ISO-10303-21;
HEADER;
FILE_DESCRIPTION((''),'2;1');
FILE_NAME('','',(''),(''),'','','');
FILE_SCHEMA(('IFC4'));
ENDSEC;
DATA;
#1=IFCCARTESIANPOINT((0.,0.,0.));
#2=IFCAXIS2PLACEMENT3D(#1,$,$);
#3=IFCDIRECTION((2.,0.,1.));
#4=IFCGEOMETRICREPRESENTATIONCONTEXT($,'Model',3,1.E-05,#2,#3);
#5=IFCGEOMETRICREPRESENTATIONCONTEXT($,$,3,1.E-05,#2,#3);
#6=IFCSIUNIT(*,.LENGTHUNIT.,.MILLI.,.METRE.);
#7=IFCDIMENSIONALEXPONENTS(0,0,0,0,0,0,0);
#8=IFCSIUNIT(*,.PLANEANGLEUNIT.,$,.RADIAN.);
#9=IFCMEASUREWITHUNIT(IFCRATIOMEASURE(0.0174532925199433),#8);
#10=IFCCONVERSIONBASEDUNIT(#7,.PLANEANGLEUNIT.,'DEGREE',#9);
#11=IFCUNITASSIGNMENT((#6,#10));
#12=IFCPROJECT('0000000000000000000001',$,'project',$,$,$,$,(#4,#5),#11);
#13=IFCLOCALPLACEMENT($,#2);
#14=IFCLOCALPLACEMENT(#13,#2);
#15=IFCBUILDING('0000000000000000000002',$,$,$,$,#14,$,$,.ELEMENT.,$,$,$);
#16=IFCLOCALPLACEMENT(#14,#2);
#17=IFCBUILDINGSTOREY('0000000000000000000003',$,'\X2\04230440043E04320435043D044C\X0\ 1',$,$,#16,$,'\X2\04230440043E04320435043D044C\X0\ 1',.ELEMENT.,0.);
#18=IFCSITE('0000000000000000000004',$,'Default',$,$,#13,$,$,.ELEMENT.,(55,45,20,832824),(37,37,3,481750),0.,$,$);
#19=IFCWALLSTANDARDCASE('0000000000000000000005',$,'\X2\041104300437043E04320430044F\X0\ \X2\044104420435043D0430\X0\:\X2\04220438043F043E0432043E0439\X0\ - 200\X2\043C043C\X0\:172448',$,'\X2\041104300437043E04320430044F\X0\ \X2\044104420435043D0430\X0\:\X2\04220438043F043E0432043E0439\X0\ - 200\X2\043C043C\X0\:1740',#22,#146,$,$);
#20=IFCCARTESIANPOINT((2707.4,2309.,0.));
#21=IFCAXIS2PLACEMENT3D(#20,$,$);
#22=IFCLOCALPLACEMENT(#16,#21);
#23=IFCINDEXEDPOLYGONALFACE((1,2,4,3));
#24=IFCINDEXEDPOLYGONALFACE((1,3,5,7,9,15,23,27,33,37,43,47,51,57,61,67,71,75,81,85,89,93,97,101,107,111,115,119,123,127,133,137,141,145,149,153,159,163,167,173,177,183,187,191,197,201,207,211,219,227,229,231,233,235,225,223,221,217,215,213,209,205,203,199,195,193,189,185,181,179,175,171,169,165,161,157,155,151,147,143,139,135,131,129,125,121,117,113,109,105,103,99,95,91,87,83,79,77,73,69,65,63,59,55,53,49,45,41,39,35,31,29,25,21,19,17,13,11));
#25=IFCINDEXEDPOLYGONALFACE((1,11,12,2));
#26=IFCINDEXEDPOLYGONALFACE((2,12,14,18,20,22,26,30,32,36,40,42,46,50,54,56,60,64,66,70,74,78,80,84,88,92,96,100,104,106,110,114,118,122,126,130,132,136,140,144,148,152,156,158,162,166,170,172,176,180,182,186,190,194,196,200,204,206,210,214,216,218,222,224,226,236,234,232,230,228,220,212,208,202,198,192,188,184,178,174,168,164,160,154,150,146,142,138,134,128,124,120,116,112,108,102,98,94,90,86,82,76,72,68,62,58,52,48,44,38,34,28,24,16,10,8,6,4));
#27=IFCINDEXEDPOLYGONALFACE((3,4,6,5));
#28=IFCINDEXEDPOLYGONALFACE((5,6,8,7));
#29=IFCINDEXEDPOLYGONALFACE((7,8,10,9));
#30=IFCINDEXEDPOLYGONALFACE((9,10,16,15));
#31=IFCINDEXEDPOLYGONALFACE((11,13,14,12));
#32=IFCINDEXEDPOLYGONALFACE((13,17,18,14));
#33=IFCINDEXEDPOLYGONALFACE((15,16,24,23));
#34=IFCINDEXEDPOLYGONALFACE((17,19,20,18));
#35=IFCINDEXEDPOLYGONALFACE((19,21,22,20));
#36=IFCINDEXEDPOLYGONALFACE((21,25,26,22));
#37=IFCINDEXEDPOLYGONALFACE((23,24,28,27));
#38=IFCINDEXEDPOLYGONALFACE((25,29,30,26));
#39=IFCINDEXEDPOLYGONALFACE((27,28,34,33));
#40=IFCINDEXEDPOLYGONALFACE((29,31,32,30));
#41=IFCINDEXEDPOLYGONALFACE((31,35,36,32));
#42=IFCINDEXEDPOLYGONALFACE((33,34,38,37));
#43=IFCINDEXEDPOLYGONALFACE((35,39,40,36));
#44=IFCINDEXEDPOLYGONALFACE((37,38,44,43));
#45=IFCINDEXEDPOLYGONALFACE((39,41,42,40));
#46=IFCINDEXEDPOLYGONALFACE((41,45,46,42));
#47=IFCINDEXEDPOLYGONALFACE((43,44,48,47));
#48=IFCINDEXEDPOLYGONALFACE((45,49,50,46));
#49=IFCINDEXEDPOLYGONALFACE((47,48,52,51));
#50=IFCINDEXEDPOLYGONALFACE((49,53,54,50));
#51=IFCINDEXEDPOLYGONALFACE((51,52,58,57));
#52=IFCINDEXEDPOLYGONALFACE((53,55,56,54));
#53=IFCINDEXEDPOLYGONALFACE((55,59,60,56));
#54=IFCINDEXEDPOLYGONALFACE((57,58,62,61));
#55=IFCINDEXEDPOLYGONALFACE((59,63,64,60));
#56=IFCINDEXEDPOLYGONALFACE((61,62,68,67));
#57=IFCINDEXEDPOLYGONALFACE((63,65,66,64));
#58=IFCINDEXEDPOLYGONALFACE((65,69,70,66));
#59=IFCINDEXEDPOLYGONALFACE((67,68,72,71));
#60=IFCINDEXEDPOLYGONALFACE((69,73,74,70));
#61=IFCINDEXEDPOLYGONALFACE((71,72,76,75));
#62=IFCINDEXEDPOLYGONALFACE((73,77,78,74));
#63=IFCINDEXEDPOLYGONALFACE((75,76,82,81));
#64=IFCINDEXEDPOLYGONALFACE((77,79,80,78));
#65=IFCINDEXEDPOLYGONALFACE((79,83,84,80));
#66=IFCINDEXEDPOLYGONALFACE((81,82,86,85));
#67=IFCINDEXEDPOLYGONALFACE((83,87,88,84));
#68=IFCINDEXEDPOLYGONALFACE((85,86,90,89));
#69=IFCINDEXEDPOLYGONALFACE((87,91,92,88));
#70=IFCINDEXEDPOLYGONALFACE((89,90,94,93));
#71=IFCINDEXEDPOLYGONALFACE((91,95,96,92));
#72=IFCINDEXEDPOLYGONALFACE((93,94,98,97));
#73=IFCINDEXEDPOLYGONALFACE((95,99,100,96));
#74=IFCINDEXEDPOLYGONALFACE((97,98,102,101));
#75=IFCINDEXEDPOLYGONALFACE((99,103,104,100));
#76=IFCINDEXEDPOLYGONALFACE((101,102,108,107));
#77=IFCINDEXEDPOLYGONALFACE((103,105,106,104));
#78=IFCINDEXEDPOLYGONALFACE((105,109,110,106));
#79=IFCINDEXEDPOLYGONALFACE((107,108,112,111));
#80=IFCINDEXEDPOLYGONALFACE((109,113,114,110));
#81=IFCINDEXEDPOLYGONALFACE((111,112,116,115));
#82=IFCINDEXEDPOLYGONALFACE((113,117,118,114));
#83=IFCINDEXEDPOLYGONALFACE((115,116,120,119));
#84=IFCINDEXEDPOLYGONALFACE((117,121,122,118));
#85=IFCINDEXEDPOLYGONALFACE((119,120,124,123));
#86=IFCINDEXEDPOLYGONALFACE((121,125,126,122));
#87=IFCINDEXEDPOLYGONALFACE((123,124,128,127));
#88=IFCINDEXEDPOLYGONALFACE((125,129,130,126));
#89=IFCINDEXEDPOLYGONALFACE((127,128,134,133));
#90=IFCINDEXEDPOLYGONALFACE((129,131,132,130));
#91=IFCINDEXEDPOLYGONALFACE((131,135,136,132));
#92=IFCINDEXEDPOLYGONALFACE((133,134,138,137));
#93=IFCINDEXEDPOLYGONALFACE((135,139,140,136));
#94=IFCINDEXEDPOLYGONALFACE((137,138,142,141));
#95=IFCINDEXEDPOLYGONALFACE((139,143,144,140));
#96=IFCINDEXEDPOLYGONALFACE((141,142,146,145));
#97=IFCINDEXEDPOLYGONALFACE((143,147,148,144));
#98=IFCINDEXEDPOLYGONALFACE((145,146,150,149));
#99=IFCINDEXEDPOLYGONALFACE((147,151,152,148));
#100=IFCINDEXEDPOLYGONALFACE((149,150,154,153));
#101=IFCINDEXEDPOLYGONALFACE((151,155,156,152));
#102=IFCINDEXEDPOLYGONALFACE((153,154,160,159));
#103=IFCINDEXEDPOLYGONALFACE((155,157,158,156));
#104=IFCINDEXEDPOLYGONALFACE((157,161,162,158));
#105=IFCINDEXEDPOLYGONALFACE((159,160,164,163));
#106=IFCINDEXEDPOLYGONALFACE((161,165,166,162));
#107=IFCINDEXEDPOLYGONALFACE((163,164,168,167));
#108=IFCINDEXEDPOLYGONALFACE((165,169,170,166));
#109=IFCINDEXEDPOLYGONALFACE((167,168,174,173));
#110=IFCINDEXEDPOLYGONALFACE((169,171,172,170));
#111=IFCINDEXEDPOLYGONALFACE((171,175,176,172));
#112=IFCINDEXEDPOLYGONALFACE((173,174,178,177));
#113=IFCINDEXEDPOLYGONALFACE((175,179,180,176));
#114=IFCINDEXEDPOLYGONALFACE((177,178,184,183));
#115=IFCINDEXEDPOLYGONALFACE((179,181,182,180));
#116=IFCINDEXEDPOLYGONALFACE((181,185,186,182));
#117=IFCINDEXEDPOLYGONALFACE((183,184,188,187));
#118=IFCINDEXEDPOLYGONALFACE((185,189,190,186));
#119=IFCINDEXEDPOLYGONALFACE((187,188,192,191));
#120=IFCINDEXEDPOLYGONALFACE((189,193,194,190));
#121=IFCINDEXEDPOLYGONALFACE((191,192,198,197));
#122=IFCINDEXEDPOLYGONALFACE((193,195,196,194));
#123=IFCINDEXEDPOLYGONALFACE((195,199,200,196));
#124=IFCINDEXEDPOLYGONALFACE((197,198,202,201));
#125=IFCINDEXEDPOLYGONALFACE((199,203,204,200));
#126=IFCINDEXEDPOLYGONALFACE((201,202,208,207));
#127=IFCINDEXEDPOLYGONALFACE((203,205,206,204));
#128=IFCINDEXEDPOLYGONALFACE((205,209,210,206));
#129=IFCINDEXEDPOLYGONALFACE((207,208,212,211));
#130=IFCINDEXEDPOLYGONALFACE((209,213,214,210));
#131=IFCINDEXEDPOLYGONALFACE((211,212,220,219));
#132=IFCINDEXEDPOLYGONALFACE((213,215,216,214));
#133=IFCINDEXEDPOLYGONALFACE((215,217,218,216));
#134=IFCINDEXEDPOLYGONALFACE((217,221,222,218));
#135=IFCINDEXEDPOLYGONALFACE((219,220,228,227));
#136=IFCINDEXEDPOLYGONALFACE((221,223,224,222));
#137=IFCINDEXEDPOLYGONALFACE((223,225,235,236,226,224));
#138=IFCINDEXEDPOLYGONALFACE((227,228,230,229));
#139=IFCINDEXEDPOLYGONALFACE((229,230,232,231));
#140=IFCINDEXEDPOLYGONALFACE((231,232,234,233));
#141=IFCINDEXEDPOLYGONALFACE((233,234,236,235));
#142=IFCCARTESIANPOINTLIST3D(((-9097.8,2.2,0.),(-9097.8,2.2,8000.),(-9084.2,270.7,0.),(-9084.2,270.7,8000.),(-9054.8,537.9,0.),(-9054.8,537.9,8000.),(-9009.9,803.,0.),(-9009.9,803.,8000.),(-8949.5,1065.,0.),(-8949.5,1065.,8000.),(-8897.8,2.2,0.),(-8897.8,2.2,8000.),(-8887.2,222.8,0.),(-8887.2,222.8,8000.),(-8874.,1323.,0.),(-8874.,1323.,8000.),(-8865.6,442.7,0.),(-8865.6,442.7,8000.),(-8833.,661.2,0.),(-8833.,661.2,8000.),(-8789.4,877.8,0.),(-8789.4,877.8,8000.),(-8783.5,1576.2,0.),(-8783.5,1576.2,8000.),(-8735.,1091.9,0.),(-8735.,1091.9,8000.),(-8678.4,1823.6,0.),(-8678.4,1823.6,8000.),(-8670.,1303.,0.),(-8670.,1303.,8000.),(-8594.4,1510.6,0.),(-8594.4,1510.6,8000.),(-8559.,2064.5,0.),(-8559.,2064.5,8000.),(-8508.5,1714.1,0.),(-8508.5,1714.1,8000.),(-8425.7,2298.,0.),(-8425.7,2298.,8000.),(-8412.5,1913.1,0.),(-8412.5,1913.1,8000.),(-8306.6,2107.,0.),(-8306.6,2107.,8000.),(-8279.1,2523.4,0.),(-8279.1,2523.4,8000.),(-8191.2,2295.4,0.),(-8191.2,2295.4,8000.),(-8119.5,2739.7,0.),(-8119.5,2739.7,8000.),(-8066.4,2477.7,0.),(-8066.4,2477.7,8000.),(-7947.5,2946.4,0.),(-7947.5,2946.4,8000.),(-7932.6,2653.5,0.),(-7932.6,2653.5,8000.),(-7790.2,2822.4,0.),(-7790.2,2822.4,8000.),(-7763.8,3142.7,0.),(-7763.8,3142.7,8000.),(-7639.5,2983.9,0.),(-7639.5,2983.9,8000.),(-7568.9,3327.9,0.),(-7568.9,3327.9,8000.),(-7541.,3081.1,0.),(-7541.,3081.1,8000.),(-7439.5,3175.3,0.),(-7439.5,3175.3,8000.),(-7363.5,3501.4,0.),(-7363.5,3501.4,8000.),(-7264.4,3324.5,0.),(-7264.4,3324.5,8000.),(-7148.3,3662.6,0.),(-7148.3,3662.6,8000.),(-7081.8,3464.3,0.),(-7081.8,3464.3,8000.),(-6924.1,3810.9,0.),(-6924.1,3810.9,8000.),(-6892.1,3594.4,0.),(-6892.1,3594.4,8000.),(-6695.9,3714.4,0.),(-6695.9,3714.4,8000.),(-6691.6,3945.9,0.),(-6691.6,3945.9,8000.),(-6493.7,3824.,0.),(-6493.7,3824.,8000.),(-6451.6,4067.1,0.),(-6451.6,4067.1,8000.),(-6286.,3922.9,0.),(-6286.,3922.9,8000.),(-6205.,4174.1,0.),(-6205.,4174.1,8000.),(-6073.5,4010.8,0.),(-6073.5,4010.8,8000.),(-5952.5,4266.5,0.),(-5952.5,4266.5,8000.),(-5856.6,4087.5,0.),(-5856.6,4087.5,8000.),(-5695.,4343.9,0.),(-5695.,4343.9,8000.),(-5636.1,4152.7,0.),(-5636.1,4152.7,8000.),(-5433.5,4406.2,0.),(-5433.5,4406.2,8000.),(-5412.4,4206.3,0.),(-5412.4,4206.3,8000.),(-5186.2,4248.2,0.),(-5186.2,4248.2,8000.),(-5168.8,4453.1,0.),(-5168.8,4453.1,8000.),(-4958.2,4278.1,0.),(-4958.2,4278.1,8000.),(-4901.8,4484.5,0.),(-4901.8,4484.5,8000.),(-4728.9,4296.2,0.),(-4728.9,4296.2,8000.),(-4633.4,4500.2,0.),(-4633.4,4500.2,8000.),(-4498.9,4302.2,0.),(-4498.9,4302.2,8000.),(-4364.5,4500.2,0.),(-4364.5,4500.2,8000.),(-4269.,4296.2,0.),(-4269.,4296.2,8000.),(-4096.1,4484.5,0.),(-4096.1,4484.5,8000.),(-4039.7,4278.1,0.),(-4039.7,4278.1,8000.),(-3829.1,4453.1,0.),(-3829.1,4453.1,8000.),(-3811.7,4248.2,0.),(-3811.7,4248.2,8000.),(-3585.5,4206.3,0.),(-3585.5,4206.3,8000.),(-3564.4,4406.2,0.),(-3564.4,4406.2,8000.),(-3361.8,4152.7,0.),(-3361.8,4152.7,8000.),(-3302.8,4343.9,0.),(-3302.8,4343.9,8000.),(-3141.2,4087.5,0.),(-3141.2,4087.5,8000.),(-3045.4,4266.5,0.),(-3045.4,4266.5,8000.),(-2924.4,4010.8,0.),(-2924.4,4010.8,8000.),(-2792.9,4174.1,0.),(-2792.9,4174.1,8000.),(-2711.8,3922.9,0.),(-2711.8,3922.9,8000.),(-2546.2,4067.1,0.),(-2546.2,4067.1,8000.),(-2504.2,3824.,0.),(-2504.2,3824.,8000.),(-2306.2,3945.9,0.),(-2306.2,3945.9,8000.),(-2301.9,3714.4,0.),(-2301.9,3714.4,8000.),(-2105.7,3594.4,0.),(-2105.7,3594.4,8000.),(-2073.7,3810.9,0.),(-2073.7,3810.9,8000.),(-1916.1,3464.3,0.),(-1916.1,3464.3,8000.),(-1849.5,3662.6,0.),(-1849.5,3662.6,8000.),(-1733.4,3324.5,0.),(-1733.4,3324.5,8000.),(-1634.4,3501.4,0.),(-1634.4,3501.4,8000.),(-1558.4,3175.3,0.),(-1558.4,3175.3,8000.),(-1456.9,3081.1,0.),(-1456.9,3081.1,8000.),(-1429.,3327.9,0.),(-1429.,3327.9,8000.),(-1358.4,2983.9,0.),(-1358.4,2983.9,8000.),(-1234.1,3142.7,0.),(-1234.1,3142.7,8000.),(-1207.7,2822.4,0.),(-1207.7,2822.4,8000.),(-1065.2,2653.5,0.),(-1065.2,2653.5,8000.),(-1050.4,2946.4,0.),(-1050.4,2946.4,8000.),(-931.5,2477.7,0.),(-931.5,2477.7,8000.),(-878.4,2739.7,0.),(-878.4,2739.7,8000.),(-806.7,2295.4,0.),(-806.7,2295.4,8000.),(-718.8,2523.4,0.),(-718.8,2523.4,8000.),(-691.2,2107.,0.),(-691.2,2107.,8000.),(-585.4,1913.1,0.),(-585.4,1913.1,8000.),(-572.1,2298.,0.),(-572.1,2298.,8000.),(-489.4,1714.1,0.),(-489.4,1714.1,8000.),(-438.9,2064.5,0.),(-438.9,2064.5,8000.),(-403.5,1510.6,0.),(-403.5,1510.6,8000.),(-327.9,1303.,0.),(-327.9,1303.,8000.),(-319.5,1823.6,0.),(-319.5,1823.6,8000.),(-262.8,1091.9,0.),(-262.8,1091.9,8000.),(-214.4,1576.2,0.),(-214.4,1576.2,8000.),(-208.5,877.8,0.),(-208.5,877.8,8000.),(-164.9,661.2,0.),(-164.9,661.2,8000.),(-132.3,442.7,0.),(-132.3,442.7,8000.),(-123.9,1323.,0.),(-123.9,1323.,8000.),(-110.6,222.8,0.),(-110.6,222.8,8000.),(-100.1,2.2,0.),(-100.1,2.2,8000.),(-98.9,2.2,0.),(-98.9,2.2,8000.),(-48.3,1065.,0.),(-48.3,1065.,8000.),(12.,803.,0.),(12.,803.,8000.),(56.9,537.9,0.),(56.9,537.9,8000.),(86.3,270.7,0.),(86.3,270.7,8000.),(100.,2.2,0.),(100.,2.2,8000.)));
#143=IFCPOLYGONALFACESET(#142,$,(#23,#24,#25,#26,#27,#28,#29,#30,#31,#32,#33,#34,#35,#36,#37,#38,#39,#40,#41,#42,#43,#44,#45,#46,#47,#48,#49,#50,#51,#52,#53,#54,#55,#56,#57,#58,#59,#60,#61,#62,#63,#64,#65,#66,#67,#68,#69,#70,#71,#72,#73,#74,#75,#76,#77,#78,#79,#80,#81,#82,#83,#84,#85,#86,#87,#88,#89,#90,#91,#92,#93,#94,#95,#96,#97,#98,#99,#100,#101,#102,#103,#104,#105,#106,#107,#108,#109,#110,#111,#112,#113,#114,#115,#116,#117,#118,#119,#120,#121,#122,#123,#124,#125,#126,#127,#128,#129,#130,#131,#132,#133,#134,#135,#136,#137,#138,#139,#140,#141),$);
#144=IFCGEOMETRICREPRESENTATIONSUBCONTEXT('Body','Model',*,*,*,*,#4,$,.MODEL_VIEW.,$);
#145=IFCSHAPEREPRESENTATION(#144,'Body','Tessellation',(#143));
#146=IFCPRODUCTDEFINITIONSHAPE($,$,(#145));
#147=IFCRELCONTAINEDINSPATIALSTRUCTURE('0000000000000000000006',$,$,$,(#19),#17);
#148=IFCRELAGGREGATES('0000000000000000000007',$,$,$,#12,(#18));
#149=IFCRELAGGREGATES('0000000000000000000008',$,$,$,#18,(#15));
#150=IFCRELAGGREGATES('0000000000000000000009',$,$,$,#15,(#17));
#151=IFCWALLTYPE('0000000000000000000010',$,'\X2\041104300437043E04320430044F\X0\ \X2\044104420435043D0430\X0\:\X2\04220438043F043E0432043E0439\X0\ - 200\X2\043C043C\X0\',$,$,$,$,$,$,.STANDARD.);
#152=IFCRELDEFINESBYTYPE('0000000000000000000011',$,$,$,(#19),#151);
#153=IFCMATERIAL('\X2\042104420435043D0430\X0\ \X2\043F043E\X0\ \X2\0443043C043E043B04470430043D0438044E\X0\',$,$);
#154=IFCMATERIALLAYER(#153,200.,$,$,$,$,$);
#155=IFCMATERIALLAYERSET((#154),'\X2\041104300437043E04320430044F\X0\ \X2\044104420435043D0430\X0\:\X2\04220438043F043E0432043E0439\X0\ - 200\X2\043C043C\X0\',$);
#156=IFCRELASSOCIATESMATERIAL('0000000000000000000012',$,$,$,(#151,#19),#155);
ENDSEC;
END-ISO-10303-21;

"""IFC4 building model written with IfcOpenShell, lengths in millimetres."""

from ifc_helpers import new_model, entity, si_unit, converted_unit, direction, frame, frame_2d, origin, place, context, subcontext, project, spatial, polyline, circle_curve, parameter, trimmed, segment, composite_curve, outline, extrude, material, layer, layer_set, layer_usage, type_object, element, save


model = new_model("IFC4")

# Units and contexts
model_context = context("Model", 3, precision=1e-05, world=origin(), true_north=direction((2.0, 0.0, 1.0)))
context_of_model = context(None, 3, precision=1e-05, world=origin(), true_north=direction((2.0, 0.0, 1.0)))
body_context = subcontext(model_context, "Body", "Model", "MODEL_VIEW")
ifc_project = project(units=[si_unit("LENGTHUNIT", "METRE", prefix="MILLI"), converted_unit("PLANEANGLEUNIT", "DEGREE", entity("IfcRatioMeasure", 0.0174532925199433), si_unit("PLANEANGLEUNIT", "RADIAN"), dimensions=[0, 0, 0, 0, 0, 0, 0])], contexts=[model_context, context_of_model])

# Site, building, storey
site_placement = place(None, origin())
site = spatial("IfcSite", under=ifc_project, at=site_placement, Name="Default", CompositionType="ELEMENT", RefLatitude=(55, 45, 20, 832824), RefLongitude=(37, 37, 3, 481750), RefElevation=0.0)
building_placement = place(site_placement, origin())
building = spatial("IfcBuilding", under=site, at=building_placement, CompositionType="ELEMENT")
storey_placement = place(building_placement, origin())
storey = spatial("IfcBuildingStorey", under=building, at=storey_placement, Name="Уровень 1", LongName="Уровень 1", CompositionType="ELEMENT", Elevation=0.0)

# Shared definitions
ifc_material = material(Name="Стена по умолчанию")
ifc_layer = layer(ifc_material, 200.0)
ifc_layer_set = layer_set([ifc_layer], Name="Базовая стена:Типовой - 200мм")
wall_type = type_object("IfcWallType", Name="Базовая стена:Типовой - 200мм", PredefinedType="STANDARD", material=ifc_layer_set)

# Wall
ifc_layer_usage_1 = layer_usage(ifc_layer_set, "AXIS2", "NEGATIVE", 100.0)
wall_1_placement = place(storey_placement, frame((2707.4, 2309.0, 0.0)))
element("IfcWallStandardCase", 1, at=wall_1_placement, inside=storey, type_object=wall_type, material=ifc_layer_usage_1, Name="Базовая стена:Типовой - 200мм:172448", ObjectType="Базовая стена:Типовой - 200мм:1740", context=body_context, shape_type="SweptSolid", body=[
    extrude(outline(composite_curve([segment(polyline([(-8897.8, 2.2), (-8887.2, 222.8)]), True, "CONTINUOUS"), segment(polyline([(-8887.2, 222.8), (-8865.6, 442.7)]), True, "CONTINUOUS"), segment(polyline([(-8865.6, 442.7), (-8833.0, 661.2)]), True, "CONTINUOUS"), segment(polyline([(-8833.0, 661.2), (-8789.4, 877.8)]), True, "CONTINUOUS"), segment(polyline([(-8789.4, 877.8), (-8735.0, 1091.9)]), True, "CONTINUOUS"), segment(polyline([(-8735.0, 1091.9), (-8670.0, 1303.0)]), True, "CONTINUOUS"), segment(polyline([(-8670.0, 1303.0), (-8594.4, 1510.6)]), True, "CONTINUOUS"), segment(polyline([(-8594.4, 1510.6), (-8508.5, 1714.1)]), True, "CONTINUOUS"), segment(polyline([(-8508.5, 1714.1), (-8412.5, 1913.1)]), True, "CONTINUOUS"), segment(polyline([(-8412.5, 1913.1), (-8306.6, 2107.0)]), True, "CONTINUOUS"), segment(polyline([(-8306.6, 2107.0), (-8191.2, 2295.4)]), True, "CONTINUOUS"), segment(polyline([(-8191.2, 2295.4), (-8066.4, 2477.7)]), True, "CONTINUOUS"), segment(polyline([(-8066.4, 2477.7), (-7932.6, 2653.5)]), True, "CONTINUOUS"), segment(polyline([(-7932.6, 2653.5), (-7790.2, 2822.4)]), True, "CONTINUOUS"), segment(polyline([(-7790.2, 2822.4), (-7639.5, 2983.9)]), True, "CONTINUOUS"), segment(polyline([(-7639.5, 2983.9), (-7541.0, 3081.1)]), True, "CONTINUOUS"), segment(polyline([(-7541.0, 3081.1), (-7439.5, 3175.3)]), True, "CONTINUOUS"), segment(polyline([(-7439.5, 3175.3), (-7264.4, 3324.5)]), True, "CONTINUOUS"), segment(polyline([(-7264.4, 3324.5), (-7081.8, 3464.3)]), True, "CONTINUOUS"), segment(polyline([(-7081.8, 3464.3), (-6892.1, 3594.4)]), True, "CONTINUOUS"), segment(polyline([(-6892.1, 3594.4), (-6695.9, 3714.4)]), True, "CONTINUOUS"), segment(polyline([(-6695.9, 3714.4), (-6493.7, 3824.0)]), True, "CONTINUOUS"), segment(polyline([(-6493.7, 3824.0), (-6286.0, 3922.9)]), True, "CONTINUOUS"), segment(polyline([(-6286.0, 3922.9), (-6073.5, 4010.8)]), True, "CONTINUOUS"), segment(polyline([(-6073.5, 4010.8), (-5856.6, 4087.5)]), True, "CONTINUOUS"), segment(polyline([(-5856.6, 4087.5), (-5636.1, 4152.7)]), True, "CONTINUOUS"), segment(polyline([(-5636.1, 4152.7), (-5412.4, 4206.3)]), True, "CONTINUOUS"), segment(polyline([(-5412.4, 4206.3), (-5186.2, 4248.2)]), True, "CONTINUOUS"), segment(polyline([(-5186.2, 4248.2), (-4958.2, 4278.1)]), True, "CONTINUOUS"), segment(polyline([(-4958.2, 4278.1), (-4728.9, 4296.2)]), True, "CONTINUOUS"), segment(polyline([(-4728.9, 4296.2), (-4498.9, 4302.2)]), True, "CONTINUOUS"), segment(polyline([(-4498.9, 4302.2), (-4269.0, 4296.2)]), True, "CONTINUOUS"), segment(polyline([(-4269.0, 4296.2), (-4039.7, 4278.1)]), True, "CONTINUOUS"), segment(polyline([(-4039.7, 4278.1), (-3811.7, 4248.2)]), True, "CONTINUOUS"), segment(polyline([(-3811.7, 4248.2), (-3585.5, 4206.3)]), True, "CONTINUOUS"), segment(polyline([(-3585.5, 4206.3), (-3361.8, 4152.7)]), True, "CONTINUOUS"), segment(polyline([(-3361.8, 4152.7), (-3141.2, 4087.5)]), True, "CONTINUOUS"), segment(polyline([(-3141.2, 4087.5), (-2924.4, 4010.8)]), True, "CONTINUOUS"), segment(polyline([(-2924.4, 4010.8), (-2711.8, 3922.9)]), True, "CONTINUOUS"), segment(polyline([(-2711.8, 3922.9), (-2504.2, 3824.0)]), True, "CONTINUOUS"), segment(polyline([(-2504.2, 3824.0), (-2301.9, 3714.4)]), True, "CONTINUOUS"), segment(polyline([(-2301.9, 3714.4), (-2105.7, 3594.4)]), True, "CONTINUOUS"), segment(polyline([(-2105.7, 3594.4), (-1916.1, 3464.3)]), True, "CONTINUOUS"), segment(polyline([(-1916.1, 3464.3), (-1733.4, 3324.5)]), True, "CONTINUOUS"), segment(polyline([(-1733.4, 3324.5), (-1558.4, 3175.3)]), True, "CONTINUOUS"), segment(polyline([(-1558.4, 3175.3), (-1456.9, 3081.1)]), True, "CONTINUOUS"), segment(polyline([(-1456.9, 3081.1), (-1358.4, 2983.9)]), True, "CONTINUOUS"), segment(polyline([(-1358.4, 2983.9), (-1207.7, 2822.4)]), True, "CONTINUOUS"), segment(polyline([(-1207.7, 2822.4), (-1065.2, 2653.5)]), True, "CONTINUOUS"), segment(polyline([(-1065.2, 2653.5), (-931.5, 2477.7)]), True, "CONTINUOUS"), segment(polyline([(-931.5, 2477.7), (-806.7, 2295.4)]), True, "CONTINUOUS"), segment(polyline([(-806.7, 2295.4), (-691.2, 2107.0)]), True, "CONTINUOUS"), segment(polyline([(-691.2, 2107.0), (-585.4, 1913.1)]), True, "CONTINUOUS"), segment(polyline([(-585.4, 1913.1), (-489.4, 1714.1)]), True, "CONTINUOUS"), segment(polyline([(-489.4, 1714.1), (-403.5, 1510.6)]), True, "CONTINUOUS"), segment(polyline([(-403.5, 1510.6), (-327.9, 1303.0)]), True, "CONTINUOUS"), segment(polyline([(-327.9, 1303.0), (-262.8, 1091.9)]), True, "CONTINUOUS"), segment(polyline([(-262.8, 1091.9), (-208.5, 877.8)]), True, "CONTINUOUS"), segment(polyline([(-208.5, 877.8), (-164.9, 661.2)]), True, "CONTINUOUS"), segment(polyline([(-164.9, 661.2), (-132.3, 442.7)]), True, "CONTINUOUS"), segment(polyline([(-132.3, 442.7), (-110.6, 222.8)]), True, "CONTINUOUS"), segment(polyline([(-110.6, 222.8), (-100.1, 2.2)]), True, "CONTINUOUS"), segment(polyline([(-100.1, 2.2), (-98.9, 2.2)]), True, "CONTINUOUS"), segment(polyline([(-98.9, 2.2), (100.0, 2.2)]), True, "CONTINUOUS"), segment(trimmed(circle_curve(frame_2d((-4498.9, -97.8), x_axis=(1.0, 0.0)), 4600.0), [parameter(1.245659)], [parameter(178.754341)], True, "PARAMETER"), True, "CONTINUOUS"), segment(polyline([(-9097.8, 2.2), (-8897.8, 2.2)]), True, "CONTINUOUS")], self_intersect=False)), origin(), (0.0, 0.0, 1.0), 8000.0),
])

save(model, "model.ifc")
